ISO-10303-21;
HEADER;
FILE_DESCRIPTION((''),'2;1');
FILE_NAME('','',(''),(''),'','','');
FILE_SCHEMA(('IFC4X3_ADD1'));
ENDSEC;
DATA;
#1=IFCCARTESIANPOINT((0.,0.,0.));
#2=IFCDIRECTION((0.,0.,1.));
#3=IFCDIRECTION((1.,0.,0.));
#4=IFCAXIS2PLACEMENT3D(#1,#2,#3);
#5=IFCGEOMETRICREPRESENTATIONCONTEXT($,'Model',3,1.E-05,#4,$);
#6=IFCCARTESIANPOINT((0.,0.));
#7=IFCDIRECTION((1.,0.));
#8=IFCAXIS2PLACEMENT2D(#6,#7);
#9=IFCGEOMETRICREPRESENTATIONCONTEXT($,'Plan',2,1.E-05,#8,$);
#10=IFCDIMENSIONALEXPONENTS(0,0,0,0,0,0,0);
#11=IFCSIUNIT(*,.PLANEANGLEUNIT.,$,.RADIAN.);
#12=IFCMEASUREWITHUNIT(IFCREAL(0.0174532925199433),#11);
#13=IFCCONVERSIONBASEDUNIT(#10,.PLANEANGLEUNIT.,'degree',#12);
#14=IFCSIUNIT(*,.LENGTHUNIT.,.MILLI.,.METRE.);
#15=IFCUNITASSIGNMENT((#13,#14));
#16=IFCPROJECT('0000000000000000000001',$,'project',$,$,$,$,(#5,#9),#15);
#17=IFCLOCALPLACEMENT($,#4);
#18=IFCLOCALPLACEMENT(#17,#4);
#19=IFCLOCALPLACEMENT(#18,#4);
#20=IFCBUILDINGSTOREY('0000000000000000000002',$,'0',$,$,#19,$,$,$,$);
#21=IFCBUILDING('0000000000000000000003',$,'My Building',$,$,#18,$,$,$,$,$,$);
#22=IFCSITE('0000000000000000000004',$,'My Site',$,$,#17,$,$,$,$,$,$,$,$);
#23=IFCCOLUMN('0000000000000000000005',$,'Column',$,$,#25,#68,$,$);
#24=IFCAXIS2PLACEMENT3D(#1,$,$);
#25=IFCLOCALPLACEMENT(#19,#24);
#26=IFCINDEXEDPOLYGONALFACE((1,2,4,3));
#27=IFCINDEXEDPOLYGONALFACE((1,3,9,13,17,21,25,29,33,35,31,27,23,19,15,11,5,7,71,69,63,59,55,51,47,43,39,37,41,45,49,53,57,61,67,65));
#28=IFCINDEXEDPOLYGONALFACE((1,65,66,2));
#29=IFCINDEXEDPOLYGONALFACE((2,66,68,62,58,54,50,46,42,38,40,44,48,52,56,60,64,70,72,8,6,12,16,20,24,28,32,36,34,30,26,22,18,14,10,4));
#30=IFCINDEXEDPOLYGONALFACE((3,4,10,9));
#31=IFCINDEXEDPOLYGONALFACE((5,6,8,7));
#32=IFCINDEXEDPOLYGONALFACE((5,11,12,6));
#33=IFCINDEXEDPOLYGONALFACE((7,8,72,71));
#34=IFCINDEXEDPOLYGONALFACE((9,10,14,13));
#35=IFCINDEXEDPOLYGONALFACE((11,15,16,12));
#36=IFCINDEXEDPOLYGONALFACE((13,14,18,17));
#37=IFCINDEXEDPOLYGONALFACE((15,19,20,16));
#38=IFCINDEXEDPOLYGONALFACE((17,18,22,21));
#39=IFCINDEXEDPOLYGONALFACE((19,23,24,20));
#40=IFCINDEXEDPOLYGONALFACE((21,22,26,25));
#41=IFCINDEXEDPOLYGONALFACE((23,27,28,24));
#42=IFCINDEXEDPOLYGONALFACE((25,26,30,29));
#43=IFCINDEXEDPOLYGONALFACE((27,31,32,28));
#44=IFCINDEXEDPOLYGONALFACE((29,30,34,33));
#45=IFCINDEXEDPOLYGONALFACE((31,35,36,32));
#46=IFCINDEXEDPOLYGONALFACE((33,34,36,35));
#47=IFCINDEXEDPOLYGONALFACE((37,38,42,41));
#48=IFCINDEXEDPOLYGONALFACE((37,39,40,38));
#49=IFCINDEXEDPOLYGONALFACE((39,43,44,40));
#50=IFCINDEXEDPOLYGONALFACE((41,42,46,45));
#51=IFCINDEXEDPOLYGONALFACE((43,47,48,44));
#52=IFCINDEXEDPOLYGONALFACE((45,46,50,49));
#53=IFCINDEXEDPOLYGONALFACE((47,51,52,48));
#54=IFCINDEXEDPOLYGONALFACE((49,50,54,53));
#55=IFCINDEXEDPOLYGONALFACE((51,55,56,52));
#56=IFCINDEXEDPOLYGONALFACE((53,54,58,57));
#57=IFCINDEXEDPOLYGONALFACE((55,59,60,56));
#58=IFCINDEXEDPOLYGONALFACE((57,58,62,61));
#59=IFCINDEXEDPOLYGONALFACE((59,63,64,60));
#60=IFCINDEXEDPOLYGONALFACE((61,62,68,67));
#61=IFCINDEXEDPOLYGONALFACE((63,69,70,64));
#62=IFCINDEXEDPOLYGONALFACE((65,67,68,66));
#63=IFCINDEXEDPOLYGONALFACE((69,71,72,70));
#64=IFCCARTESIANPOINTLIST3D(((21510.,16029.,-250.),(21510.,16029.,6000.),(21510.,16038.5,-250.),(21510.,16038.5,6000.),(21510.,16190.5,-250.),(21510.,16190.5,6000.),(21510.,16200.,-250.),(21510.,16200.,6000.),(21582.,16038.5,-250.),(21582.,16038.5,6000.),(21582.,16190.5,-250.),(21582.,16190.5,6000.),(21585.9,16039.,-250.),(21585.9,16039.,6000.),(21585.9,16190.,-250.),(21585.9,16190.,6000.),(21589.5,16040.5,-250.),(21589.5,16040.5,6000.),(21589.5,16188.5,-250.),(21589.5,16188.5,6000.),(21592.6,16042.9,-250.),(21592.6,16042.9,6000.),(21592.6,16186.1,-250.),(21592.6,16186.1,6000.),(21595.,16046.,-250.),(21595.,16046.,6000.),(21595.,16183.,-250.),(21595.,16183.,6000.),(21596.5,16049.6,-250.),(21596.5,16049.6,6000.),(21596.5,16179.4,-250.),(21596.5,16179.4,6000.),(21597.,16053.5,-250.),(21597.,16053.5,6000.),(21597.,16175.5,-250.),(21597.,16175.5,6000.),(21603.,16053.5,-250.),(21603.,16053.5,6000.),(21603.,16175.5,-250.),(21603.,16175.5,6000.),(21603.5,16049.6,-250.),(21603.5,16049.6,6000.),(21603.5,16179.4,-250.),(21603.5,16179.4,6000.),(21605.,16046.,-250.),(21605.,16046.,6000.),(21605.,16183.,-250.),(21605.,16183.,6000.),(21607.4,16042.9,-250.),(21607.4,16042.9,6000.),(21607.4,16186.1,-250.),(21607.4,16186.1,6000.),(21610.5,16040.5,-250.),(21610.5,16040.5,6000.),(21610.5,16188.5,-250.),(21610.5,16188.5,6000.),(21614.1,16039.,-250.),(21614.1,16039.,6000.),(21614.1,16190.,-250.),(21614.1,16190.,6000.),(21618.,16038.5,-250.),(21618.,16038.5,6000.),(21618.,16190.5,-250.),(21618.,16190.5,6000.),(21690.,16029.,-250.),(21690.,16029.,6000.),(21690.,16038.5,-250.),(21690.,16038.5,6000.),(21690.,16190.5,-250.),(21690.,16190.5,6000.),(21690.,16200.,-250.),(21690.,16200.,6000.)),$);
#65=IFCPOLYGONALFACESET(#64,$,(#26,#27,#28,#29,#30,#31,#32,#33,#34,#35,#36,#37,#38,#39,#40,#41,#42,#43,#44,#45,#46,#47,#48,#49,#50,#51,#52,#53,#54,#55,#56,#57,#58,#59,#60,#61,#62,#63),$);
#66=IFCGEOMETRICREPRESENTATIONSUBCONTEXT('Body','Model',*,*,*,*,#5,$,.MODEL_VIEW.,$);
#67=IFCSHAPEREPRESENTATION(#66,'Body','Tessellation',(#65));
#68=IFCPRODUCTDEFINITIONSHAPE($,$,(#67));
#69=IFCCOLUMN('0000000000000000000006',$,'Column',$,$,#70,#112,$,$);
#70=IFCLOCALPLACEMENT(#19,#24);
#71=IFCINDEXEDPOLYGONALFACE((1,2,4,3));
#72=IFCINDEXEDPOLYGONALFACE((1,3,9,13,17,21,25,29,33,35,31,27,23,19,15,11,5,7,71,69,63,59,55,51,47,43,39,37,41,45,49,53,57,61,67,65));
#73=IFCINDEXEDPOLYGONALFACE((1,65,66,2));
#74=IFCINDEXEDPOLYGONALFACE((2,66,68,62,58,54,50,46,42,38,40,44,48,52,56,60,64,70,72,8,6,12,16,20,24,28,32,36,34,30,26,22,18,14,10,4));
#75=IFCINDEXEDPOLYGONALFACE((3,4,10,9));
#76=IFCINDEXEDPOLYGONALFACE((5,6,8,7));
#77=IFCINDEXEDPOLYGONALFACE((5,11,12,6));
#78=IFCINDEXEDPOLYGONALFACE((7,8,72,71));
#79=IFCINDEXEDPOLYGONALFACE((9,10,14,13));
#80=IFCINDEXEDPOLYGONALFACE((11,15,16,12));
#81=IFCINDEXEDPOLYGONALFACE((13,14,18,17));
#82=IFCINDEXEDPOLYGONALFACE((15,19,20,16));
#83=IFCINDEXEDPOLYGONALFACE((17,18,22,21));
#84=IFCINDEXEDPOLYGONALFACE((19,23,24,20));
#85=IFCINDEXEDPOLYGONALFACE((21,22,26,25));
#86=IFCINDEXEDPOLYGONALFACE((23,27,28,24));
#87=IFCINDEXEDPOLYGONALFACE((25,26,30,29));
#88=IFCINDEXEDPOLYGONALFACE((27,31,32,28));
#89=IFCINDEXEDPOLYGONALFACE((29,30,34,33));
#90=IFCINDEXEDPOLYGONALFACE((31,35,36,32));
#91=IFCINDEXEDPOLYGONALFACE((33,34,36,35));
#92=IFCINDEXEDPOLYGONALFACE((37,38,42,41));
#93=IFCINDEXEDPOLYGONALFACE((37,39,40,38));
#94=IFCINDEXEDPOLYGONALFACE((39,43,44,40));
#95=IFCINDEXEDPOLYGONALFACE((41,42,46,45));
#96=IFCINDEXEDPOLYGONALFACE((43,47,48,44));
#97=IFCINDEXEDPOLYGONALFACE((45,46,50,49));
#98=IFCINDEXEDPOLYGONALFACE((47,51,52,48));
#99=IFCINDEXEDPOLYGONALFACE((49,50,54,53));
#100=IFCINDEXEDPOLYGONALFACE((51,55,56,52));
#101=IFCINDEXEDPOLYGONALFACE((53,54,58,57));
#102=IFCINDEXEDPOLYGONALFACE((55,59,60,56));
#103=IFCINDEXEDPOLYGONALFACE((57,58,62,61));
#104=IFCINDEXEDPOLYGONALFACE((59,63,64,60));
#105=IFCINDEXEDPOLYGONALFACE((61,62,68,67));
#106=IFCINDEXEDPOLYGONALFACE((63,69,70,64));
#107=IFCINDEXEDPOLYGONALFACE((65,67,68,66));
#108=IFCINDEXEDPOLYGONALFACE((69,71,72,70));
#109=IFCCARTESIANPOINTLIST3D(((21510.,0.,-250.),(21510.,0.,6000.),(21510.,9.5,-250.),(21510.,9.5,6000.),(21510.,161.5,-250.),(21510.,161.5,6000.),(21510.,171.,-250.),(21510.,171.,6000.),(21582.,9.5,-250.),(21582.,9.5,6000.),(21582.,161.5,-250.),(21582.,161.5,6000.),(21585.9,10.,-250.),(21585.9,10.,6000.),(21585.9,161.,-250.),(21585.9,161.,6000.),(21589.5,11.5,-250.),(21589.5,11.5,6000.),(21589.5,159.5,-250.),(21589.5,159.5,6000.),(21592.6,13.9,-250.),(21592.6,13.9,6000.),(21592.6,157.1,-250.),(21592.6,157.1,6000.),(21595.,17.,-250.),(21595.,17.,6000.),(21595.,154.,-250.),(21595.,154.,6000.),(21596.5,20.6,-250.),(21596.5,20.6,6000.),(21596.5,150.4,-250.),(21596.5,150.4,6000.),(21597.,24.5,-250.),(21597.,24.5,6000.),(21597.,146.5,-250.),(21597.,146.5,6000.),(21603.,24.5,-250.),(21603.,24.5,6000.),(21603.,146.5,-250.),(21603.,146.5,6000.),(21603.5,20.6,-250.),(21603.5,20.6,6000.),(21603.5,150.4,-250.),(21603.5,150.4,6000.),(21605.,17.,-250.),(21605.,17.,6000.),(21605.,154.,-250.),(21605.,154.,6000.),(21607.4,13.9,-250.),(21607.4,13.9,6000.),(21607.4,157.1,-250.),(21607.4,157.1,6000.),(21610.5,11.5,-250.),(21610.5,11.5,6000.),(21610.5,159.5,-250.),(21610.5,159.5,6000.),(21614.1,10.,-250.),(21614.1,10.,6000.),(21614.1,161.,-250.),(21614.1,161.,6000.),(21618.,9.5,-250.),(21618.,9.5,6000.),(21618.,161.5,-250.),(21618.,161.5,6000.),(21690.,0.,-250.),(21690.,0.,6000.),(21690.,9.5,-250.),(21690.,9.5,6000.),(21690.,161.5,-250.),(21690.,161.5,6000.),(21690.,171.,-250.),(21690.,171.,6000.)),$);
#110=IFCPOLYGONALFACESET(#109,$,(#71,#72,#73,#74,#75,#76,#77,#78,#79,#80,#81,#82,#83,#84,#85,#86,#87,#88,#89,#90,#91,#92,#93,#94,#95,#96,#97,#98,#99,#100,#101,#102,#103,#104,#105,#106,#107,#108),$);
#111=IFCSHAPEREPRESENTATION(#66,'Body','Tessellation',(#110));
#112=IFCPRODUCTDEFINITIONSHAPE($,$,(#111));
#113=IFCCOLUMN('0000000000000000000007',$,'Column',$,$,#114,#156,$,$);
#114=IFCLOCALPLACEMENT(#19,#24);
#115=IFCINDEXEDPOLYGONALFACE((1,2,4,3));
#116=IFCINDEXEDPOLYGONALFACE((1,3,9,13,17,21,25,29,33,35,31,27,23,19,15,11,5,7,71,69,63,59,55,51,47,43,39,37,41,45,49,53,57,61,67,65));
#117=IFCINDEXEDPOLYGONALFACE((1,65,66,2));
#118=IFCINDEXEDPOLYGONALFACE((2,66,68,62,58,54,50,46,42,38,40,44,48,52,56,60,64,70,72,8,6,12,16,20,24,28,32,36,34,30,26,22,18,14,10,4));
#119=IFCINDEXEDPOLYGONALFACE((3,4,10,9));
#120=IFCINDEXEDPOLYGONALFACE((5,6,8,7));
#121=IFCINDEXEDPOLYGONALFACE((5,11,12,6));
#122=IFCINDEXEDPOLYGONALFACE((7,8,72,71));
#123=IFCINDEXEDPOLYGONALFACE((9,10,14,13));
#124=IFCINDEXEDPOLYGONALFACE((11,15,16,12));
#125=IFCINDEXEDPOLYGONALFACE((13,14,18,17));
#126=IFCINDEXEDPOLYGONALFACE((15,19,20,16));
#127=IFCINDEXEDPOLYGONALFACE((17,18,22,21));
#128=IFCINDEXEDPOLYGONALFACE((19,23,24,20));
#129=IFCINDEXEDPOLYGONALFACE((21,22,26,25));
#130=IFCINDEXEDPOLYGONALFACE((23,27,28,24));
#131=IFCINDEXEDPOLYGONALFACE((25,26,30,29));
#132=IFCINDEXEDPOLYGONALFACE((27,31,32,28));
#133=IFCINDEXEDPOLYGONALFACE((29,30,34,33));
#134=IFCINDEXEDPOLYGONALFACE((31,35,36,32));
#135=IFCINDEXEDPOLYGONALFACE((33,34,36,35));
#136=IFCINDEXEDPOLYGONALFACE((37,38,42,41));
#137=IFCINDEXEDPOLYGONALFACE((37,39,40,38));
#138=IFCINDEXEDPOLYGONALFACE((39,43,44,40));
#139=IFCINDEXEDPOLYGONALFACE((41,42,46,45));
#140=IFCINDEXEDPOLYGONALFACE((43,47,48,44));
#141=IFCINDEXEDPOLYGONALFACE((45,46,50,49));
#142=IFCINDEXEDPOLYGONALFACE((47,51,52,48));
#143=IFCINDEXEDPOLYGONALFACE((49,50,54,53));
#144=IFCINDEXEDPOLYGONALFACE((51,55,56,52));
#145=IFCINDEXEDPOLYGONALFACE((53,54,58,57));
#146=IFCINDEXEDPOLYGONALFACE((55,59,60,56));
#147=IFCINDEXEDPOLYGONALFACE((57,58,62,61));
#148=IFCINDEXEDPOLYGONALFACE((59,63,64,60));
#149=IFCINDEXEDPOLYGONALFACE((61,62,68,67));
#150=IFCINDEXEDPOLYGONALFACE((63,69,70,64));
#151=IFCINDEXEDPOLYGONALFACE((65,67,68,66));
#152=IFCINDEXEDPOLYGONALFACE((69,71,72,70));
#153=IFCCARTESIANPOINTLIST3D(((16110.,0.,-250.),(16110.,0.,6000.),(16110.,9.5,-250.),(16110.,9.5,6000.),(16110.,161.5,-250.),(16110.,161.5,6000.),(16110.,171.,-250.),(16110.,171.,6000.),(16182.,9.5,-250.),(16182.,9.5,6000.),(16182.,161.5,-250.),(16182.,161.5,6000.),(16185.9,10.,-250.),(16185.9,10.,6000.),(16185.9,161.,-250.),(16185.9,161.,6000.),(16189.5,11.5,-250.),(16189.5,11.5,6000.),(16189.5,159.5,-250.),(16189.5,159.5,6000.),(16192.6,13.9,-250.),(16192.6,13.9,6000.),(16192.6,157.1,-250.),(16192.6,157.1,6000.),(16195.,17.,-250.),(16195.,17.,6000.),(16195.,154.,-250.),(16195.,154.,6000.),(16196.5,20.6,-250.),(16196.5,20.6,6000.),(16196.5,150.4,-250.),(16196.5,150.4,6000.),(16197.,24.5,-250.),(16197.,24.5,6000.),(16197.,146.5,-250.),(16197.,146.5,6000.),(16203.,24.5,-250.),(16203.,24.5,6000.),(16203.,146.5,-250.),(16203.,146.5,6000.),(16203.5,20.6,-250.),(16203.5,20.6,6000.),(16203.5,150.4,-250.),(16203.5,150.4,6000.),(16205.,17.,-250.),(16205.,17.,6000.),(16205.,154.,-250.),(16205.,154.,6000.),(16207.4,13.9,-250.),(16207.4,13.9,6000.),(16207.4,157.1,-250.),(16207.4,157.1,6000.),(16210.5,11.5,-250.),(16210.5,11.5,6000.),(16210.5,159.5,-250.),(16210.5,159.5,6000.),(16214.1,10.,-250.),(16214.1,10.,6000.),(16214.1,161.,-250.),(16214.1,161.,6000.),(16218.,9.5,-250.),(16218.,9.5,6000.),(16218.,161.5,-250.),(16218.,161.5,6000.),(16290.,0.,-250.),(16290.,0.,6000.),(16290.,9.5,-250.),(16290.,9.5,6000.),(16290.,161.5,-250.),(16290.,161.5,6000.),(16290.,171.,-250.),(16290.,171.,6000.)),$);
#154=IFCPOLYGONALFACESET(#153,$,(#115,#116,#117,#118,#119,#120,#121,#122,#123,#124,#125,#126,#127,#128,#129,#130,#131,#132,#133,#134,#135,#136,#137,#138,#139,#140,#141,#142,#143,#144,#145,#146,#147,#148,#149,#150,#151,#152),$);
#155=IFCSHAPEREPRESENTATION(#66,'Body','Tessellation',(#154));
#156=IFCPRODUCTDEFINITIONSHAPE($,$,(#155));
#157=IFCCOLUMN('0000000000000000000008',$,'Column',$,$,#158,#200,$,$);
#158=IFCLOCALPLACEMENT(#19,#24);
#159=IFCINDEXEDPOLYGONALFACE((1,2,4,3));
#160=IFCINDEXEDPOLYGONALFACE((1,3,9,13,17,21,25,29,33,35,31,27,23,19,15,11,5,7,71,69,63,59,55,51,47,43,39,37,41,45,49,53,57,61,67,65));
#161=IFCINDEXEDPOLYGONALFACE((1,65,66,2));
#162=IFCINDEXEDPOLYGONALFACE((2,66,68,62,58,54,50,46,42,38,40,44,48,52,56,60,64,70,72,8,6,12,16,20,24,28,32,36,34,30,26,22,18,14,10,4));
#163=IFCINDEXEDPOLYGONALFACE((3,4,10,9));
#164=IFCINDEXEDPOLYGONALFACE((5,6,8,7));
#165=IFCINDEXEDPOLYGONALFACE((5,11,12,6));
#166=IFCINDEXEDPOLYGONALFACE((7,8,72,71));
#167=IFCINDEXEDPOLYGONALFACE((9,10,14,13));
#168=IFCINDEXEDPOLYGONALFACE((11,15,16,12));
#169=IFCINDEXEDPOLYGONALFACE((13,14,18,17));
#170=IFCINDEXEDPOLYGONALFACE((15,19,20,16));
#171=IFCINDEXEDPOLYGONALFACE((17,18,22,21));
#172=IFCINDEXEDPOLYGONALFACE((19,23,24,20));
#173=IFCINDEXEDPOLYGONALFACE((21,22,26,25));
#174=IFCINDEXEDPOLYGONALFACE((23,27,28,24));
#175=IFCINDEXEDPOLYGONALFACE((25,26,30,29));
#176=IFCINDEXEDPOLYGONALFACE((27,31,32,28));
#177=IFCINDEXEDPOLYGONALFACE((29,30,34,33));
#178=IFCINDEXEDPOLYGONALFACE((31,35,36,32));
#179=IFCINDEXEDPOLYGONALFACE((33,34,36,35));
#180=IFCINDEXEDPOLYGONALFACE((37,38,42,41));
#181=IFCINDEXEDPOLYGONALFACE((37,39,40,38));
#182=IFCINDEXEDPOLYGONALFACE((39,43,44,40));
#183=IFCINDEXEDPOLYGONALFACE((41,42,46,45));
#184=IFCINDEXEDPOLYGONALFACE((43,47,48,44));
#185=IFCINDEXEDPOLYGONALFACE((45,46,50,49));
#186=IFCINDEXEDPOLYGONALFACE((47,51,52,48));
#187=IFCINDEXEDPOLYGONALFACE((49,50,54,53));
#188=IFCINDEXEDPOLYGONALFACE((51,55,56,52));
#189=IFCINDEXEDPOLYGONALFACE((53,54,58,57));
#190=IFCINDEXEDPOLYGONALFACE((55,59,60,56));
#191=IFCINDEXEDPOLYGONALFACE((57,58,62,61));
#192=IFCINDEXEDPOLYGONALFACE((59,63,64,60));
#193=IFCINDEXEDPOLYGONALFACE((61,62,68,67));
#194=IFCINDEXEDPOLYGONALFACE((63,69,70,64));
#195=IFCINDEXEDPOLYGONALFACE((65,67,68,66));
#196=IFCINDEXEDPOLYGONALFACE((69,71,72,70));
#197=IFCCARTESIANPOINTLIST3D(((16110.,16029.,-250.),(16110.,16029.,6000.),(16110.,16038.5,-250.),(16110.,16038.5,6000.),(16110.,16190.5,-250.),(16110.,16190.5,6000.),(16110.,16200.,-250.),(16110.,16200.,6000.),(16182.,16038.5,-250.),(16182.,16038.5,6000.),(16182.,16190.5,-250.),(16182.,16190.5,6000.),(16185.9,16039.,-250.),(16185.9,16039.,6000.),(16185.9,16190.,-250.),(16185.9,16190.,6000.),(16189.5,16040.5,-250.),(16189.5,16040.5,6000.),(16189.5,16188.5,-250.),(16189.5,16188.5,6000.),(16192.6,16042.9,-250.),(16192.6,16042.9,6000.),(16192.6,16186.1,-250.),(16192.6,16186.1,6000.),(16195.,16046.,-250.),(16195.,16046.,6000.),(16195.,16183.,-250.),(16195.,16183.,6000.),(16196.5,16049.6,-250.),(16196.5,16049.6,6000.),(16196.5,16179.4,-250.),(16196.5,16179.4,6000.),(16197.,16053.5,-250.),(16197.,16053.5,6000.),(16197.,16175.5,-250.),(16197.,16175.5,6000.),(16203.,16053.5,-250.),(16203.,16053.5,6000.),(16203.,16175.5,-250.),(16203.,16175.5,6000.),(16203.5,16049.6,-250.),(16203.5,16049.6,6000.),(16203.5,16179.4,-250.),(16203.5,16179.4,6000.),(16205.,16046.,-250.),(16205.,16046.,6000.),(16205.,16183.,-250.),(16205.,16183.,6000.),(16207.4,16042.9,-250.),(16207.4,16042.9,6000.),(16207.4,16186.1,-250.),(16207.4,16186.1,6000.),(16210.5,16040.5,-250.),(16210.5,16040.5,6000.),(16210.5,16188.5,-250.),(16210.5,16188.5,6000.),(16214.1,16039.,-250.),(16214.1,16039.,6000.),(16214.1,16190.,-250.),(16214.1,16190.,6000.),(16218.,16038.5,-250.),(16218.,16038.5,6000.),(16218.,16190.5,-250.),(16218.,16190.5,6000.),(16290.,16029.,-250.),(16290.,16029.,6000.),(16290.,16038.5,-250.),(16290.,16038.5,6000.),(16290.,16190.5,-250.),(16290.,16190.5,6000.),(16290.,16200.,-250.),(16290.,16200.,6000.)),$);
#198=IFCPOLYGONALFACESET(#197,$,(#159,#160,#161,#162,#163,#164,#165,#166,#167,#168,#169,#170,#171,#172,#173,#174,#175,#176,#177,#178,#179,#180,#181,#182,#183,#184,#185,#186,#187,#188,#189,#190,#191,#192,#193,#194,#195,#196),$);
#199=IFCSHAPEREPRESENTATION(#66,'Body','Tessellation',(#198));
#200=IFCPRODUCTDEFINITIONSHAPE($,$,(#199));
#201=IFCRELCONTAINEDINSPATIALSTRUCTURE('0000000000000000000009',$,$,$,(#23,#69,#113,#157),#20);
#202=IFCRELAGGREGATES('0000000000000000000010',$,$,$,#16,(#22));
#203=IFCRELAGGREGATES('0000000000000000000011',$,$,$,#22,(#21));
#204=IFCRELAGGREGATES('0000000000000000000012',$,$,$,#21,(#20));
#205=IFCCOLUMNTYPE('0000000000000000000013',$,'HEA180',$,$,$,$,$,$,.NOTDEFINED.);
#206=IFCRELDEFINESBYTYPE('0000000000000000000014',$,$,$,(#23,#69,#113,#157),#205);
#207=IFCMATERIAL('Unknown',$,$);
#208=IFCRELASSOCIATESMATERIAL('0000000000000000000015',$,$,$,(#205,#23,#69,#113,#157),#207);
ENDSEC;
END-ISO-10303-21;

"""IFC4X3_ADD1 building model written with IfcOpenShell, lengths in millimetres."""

from ifc_helpers import new_model, entity, si_unit, converted_unit, frame, origin_with_axes, origin_2d_with_axis, place, context, subcontext, project, spatial, i_section, extrude, material, material_profile, profile_set, profile_usage, type_object, element, save


model = new_model("IFC4X3_ADD1")

# Units and contexts
model_context = context("Model", 3, precision=1e-05, world=origin_with_axes())
plan_context = context("Plan", 2, precision=1e-05, world=origin_2d_with_axis())
body_context = subcontext(model_context, "Body", "Model", "MODEL_VIEW")
ifc_project = project(units=[converted_unit("PLANEANGLEUNIT", "degree", entity("IfcReal", 0.0174532925199433), si_unit("PLANEANGLEUNIT", "RADIAN"), dimensions=[0, 0, 0, 0, 0, 0, 0]), si_unit("LENGTHUNIT", "METRE", prefix="MILLI")], contexts=[model_context, plan_context])

# Site, building, storey
site_placement = place(None, origin_with_axes())
site = spatial("IfcSite", under=ifc_project, at=site_placement, Name="My Site")
building_placement = place(site_placement, origin_with_axes())
building = spatial("IfcBuilding", under=site, at=building_placement, Name="My Building")
storey_placement = place(building_placement, origin_with_axes())
storey = spatial("IfcBuildingStorey", under=building, at=storey_placement, Name="0")

# Columns
ifc_material = material(Name="Unknown")
ifc_material_profile_1 = material_profile(ifc_material, i_section(OverallWidth=180.0, OverallDepth=171.0, WebThickness=6.0, FlangeThickness=9.5, FilletRadius=15.0))
ifc_profile_set_1 = profile_set([ifc_material_profile_1])
column_type = type_object("IfcColumnType", Name="HEA180", PredefinedType="NOTDEFINED", material=ifc_profile_set_1)
ifc_profile_usage_1 = profile_usage(ifc_profile_set_1, cardinal=8)
column_1_placement = place(storey_placement, frame((21600.0, 16200.0, -250.0), z_axis=(0.0, 0.0, 1.0), x_axis=(1.0, 0.0, 0.0)))
element("IfcColumn", 1, at=column_1_placement, inside=storey, type_object=column_type, material=ifc_profile_usage_1, Name="Column", context=body_context, shape_type="SweptSolid", body=[
    extrude(i_section(OverallWidth=180.0, OverallDepth=171.0, WebThickness=6.0, FlangeThickness=9.5, FilletRadius=15.0), frame((0.0, -85.5, 0.0), z_axis=(0.0, 0.0, 1.0), x_axis=(1.0, 0.0, 0.0)), (0.0, 0.0, 1.0), 6250.0),
])
ifc_profile_usage_2 = profile_usage(ifc_profile_set_1, cardinal=2)
column_2_placement = place(storey_placement, frame((21600.0, 0.0, -250.0), z_axis=(0.0, 0.0, 1.0), x_axis=(1.0, 0.0, 0.0)))
element("IfcColumn", 2, at=column_2_placement, inside=storey, type_object=column_type, material=ifc_profile_usage_2, Name="Column", context=body_context, shape_type="SweptSolid", body=[
    extrude(i_section(OverallWidth=180.0, OverallDepth=171.0, WebThickness=6.0, FlangeThickness=9.5, FilletRadius=15.0), frame((0.0, 85.5, 0.0), z_axis=(0.0, 0.0, 1.0), x_axis=(1.0, 0.0, 0.0)), (0.0, 0.0, 1.0), 6250.0),
])
ifc_profile_usage_3 = profile_usage(ifc_profile_set_1, cardinal=2)
column_3_placement = place(storey_placement, frame((16200.0, 0.0, -250.0), z_axis=(0.0, 0.0, 1.0), x_axis=(1.0, 0.0, 0.0)))
element("IfcColumn", 3, at=column_3_placement, inside=storey, type_object=column_type, material=ifc_profile_usage_3, Name="Column", context=body_context, shape_type="SweptSolid", body=[
    extrude(i_section(OverallWidth=180.0, OverallDepth=171.0, WebThickness=6.0, FlangeThickness=9.5, FilletRadius=15.0), frame((0.0, 85.5, 0.0), z_axis=(0.0, 0.0, 1.0), x_axis=(1.0, 0.0, 0.0)), (0.0, 0.0, 1.0), 6250.0),
])
ifc_profile_usage_4 = profile_usage(ifc_profile_set_1, cardinal=8)
column_4_placement = place(storey_placement, frame((16200.0, 16200.0, -250.0), z_axis=(0.0, 0.0, 1.0), x_axis=(1.0, 0.0, 0.0)))
element("IfcColumn", 4, at=column_4_placement, inside=storey, type_object=column_type, material=ifc_profile_usage_4, Name="Column", context=body_context, shape_type="SweptSolid", body=[
    extrude(i_section(OverallWidth=180.0, OverallDepth=171.0, WebThickness=6.0, FlangeThickness=9.5, FilletRadius=15.0), frame((0.0, -85.5, 0.0), z_axis=(0.0, 0.0, 1.0), x_axis=(1.0, 0.0, 0.0)), (0.0, 0.0, 1.0), 6250.0),
])

save(model, "model.ifc")
